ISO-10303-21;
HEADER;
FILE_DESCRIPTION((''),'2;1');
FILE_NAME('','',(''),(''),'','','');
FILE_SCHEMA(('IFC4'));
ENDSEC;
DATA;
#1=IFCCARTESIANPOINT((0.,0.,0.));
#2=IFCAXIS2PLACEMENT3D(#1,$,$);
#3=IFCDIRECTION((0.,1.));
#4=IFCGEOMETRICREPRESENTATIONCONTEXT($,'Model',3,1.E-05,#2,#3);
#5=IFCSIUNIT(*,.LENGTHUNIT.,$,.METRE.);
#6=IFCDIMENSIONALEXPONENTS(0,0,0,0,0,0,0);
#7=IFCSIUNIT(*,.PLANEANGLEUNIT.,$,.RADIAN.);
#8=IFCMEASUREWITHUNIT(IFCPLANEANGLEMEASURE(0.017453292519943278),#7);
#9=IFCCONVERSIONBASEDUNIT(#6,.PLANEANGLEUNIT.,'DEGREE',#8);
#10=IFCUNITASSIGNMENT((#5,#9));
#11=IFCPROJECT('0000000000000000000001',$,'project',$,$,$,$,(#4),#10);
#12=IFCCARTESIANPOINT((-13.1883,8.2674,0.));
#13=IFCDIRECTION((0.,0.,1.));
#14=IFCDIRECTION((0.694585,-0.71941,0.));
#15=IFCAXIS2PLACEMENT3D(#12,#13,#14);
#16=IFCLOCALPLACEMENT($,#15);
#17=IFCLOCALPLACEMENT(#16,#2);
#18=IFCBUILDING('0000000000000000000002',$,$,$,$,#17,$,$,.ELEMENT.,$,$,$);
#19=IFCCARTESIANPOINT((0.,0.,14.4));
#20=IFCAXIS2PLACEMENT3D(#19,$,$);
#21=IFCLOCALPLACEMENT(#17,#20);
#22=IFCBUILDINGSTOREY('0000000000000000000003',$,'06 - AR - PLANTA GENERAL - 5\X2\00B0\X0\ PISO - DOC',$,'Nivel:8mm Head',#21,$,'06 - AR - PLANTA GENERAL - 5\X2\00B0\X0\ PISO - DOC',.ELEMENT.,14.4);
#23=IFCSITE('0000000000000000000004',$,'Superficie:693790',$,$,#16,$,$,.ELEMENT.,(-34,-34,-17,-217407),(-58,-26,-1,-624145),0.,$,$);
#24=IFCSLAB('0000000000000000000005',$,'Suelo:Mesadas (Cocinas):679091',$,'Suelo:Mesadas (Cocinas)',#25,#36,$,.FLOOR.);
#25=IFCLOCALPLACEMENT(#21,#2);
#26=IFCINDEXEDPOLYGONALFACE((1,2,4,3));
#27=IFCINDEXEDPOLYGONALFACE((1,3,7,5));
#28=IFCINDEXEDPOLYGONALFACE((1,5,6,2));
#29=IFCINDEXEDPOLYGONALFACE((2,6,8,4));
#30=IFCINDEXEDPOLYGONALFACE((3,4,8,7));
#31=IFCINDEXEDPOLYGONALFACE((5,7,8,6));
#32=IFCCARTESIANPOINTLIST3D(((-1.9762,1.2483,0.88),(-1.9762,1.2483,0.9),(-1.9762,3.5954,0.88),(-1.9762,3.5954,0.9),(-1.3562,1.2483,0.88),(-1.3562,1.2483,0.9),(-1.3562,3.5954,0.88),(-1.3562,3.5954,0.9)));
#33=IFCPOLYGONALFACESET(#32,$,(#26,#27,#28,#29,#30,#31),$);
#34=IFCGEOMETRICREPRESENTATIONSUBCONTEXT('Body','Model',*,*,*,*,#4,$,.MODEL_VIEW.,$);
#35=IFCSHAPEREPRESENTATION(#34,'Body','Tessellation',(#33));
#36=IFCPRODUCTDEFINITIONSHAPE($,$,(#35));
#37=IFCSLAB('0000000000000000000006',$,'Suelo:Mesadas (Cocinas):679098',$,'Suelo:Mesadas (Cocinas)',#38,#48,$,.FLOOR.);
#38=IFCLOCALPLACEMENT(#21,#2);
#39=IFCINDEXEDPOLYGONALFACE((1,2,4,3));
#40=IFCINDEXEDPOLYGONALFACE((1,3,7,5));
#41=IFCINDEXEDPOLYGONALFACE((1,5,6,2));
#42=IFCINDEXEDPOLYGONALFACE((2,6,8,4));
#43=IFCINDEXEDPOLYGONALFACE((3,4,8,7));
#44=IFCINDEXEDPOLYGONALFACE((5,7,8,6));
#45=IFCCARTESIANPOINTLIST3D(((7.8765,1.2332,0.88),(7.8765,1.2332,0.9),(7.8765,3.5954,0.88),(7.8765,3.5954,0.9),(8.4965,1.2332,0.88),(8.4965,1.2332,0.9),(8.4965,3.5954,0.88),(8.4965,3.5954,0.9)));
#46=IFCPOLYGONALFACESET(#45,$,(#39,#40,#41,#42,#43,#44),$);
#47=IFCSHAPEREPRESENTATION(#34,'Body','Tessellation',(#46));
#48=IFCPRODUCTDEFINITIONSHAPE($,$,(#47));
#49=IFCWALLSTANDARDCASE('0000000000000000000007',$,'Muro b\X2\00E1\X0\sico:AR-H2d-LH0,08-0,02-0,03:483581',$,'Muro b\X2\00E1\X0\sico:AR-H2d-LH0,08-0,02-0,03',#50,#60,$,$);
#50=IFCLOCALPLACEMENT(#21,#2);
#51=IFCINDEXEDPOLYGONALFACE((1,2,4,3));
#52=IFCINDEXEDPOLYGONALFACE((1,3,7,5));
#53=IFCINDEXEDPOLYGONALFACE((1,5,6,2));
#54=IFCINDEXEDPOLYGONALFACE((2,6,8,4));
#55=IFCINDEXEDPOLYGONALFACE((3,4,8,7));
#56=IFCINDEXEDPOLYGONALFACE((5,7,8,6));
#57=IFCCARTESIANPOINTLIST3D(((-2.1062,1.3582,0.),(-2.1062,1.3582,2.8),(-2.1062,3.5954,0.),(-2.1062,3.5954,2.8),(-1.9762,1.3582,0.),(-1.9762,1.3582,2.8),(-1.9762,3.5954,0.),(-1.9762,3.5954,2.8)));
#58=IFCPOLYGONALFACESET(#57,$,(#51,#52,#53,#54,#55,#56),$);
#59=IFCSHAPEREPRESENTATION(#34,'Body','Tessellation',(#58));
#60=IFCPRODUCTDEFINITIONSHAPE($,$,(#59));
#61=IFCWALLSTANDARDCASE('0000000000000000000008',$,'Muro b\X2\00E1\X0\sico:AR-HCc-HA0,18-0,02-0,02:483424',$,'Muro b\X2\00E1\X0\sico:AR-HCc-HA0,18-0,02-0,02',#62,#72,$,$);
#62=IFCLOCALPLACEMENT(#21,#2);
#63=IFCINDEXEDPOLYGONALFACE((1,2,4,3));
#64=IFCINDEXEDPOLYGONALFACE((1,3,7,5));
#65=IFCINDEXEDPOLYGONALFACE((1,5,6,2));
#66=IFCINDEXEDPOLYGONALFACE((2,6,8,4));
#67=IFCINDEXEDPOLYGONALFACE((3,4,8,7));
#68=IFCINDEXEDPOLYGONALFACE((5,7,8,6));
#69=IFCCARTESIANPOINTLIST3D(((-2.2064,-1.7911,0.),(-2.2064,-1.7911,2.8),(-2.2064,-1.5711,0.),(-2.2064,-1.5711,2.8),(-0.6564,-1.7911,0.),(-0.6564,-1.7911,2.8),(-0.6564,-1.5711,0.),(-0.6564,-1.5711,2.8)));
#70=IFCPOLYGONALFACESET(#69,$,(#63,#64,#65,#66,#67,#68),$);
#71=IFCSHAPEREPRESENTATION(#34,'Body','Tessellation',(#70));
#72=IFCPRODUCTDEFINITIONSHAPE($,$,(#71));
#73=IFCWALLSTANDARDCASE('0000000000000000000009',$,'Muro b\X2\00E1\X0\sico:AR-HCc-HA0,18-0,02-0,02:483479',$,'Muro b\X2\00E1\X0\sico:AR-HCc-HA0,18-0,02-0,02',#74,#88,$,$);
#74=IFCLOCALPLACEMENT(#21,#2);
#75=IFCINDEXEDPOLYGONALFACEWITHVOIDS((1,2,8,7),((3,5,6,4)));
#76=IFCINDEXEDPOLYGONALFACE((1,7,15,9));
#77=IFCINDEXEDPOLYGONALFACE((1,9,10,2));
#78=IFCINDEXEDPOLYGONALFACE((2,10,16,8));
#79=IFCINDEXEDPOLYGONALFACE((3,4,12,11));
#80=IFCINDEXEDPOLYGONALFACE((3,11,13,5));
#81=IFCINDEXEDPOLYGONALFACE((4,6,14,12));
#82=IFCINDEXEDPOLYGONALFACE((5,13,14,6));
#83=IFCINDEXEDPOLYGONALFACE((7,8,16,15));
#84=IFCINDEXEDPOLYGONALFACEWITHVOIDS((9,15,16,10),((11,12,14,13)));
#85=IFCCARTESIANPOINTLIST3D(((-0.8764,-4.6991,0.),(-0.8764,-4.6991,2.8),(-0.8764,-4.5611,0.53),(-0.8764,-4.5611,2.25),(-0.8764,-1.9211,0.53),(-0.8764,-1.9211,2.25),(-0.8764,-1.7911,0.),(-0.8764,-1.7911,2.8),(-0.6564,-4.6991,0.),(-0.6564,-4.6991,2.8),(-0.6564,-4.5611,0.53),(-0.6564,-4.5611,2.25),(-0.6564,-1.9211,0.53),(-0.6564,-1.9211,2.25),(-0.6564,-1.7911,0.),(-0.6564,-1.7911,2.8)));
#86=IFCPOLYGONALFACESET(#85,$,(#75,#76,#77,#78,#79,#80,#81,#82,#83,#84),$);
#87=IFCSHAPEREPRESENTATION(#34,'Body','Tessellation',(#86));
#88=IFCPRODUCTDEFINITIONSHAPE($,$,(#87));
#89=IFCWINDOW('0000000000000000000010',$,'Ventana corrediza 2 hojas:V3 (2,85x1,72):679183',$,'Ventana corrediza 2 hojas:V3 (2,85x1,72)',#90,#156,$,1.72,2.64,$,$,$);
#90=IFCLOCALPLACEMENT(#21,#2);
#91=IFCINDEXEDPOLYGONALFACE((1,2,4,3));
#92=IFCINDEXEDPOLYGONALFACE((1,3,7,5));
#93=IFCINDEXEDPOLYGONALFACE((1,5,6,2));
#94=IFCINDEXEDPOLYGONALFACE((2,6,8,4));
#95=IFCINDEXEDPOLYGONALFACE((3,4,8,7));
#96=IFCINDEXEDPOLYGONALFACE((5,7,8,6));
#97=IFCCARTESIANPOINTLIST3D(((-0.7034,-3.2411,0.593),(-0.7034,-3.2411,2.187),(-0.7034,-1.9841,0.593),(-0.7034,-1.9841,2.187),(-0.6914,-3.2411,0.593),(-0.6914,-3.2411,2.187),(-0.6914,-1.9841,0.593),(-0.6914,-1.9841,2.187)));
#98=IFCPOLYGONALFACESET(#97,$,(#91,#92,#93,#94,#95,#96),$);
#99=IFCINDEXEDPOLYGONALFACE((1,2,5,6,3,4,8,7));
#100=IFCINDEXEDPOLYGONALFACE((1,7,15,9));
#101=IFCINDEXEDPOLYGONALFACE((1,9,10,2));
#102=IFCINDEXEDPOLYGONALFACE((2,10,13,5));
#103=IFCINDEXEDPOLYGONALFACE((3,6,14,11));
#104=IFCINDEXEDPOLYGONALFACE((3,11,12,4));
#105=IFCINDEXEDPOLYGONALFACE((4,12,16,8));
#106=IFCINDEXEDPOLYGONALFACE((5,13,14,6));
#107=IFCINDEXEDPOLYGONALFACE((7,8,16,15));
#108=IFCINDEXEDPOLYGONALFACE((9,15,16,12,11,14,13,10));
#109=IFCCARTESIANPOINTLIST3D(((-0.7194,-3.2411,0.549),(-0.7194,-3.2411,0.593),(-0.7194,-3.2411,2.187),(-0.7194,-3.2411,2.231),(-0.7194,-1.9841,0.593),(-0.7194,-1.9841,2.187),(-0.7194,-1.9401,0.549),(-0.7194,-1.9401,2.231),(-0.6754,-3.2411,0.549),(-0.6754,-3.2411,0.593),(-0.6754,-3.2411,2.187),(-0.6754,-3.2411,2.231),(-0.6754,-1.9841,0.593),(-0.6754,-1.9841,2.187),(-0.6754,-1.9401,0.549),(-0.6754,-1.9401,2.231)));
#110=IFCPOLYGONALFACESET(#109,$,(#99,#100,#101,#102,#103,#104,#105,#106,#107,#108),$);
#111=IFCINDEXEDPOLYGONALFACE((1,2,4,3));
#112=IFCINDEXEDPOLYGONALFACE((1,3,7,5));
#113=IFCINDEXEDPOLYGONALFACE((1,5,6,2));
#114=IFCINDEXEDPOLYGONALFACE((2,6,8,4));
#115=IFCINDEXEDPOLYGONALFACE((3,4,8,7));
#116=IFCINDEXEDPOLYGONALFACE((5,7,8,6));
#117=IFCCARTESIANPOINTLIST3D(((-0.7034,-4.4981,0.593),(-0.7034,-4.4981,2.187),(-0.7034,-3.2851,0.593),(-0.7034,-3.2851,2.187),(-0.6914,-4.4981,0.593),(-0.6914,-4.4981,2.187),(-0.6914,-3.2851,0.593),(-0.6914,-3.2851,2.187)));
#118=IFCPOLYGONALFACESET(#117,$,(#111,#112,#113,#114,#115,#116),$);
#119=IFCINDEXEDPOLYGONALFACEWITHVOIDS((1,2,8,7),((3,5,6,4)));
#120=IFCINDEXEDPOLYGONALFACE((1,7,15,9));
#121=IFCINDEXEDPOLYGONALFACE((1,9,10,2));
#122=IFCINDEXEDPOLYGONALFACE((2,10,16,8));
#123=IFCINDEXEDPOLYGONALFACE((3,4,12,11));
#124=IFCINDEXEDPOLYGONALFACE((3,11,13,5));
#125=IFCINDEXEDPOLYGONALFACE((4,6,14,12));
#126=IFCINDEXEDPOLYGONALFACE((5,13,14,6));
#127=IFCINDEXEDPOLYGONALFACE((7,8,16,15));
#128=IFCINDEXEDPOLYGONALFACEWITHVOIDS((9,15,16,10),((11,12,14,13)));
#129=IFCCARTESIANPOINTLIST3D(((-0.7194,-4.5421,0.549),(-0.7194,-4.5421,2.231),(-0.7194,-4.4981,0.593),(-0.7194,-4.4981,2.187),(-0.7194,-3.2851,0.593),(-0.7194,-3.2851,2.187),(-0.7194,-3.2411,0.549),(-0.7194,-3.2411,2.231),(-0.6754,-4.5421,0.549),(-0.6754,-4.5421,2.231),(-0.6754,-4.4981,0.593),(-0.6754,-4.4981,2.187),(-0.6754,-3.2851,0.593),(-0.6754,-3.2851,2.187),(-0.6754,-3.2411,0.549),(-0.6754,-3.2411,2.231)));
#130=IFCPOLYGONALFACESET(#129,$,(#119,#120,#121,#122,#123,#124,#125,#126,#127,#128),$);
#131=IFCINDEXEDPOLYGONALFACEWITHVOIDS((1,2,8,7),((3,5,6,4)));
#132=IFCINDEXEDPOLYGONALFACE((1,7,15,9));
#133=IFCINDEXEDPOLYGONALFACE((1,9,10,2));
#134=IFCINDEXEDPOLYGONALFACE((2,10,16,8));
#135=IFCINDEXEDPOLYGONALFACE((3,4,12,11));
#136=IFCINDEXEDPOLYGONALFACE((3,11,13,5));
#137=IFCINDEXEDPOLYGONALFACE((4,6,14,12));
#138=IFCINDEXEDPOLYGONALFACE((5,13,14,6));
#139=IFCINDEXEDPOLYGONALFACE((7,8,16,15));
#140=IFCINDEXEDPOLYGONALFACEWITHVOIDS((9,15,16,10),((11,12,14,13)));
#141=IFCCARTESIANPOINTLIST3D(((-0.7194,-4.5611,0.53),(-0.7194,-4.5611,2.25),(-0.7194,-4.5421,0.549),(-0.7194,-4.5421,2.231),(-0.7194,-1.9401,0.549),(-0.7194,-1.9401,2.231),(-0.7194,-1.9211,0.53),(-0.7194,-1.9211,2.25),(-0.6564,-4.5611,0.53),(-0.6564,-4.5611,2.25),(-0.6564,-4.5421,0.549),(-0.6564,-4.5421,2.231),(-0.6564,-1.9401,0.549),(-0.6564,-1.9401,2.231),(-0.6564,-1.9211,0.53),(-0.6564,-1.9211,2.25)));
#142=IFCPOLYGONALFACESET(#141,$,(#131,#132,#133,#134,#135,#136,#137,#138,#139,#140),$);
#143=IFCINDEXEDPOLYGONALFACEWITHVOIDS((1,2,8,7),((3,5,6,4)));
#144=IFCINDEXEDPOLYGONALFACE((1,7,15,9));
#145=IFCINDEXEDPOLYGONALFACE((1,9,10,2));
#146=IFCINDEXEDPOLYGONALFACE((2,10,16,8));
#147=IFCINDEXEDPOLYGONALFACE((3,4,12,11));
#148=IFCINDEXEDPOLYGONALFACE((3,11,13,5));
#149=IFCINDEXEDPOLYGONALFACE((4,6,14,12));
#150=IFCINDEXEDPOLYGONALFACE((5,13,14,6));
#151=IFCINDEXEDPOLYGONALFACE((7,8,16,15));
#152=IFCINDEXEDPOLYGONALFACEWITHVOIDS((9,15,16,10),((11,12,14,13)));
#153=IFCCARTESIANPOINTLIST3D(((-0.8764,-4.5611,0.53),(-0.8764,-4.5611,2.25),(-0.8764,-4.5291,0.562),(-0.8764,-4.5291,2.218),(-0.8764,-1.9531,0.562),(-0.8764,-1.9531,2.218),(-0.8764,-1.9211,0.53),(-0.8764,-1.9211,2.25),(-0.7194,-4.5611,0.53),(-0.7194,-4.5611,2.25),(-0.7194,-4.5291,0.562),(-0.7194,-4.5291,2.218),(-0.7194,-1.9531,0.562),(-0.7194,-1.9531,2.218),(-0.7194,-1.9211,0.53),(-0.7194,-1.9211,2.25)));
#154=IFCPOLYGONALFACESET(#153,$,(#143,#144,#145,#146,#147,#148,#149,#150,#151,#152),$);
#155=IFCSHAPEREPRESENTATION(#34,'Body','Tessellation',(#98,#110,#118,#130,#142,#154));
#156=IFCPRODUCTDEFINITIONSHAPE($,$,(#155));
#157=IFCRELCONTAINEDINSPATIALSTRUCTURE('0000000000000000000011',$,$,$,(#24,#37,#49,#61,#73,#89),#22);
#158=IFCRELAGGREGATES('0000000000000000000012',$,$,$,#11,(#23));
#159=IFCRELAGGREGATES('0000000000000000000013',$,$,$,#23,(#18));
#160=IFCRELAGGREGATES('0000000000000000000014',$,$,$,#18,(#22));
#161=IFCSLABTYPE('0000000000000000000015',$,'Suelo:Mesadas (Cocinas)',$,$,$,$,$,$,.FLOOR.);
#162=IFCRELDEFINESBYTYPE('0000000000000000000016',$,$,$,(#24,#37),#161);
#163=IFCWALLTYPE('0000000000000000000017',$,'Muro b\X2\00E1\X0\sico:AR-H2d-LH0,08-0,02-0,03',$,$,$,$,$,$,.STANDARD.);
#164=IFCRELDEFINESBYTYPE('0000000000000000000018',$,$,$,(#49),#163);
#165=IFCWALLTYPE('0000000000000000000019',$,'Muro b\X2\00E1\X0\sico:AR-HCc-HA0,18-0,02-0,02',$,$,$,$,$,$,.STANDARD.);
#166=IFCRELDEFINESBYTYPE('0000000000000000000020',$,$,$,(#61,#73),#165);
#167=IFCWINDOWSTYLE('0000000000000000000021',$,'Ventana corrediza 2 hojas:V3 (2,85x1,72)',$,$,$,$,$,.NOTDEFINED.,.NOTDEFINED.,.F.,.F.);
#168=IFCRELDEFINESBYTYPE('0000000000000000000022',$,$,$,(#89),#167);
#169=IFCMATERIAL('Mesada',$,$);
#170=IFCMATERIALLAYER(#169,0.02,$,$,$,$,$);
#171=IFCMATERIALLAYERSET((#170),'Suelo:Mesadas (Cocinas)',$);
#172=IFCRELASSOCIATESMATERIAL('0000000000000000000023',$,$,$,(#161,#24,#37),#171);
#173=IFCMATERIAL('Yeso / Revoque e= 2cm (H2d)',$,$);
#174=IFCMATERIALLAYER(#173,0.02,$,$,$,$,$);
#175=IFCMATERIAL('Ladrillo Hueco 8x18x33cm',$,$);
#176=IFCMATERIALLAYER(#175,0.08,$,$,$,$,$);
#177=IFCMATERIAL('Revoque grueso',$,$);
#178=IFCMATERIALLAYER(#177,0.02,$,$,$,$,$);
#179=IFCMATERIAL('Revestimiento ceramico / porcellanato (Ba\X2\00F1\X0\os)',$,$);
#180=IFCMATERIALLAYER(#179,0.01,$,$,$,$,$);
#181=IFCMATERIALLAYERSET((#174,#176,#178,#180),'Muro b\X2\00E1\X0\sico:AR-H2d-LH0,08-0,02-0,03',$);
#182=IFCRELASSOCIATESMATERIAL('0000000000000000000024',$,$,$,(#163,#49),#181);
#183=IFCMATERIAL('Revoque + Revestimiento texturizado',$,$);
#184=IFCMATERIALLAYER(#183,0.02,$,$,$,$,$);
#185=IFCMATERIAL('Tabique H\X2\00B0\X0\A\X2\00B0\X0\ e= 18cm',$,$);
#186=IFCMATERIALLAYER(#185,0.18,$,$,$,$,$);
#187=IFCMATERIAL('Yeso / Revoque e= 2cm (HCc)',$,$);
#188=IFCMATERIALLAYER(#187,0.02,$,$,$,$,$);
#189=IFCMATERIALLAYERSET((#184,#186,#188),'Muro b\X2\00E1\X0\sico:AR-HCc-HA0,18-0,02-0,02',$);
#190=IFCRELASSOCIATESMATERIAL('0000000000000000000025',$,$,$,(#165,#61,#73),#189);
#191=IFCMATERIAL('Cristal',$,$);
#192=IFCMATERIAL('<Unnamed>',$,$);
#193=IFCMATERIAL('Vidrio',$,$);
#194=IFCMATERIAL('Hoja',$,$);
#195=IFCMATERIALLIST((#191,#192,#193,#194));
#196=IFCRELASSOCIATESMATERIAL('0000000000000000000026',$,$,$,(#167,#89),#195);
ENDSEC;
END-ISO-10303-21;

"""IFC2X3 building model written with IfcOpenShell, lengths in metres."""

from ifc_helpers import new_model, entity, si_unit, converted_unit, direction, frame, frame_2d, origin, origin_2d_with_axis, place, context, subcontext, project, spatial, polyline, rectangle, outline, extrude, source, transform, mapped, material, material_list, layer, layer_set, layer_usage, type_object, type_shapes, element, fill, save


model = new_model("IFC2X3")

# Units and contexts
model_context = context("Model", 3, precision=1e-05, world=origin(), true_north=direction((0.0, 1.0)))
body_context = subcontext(model_context, "Body", "Model", "MODEL_VIEW")
ifc_project = project(units=[si_unit("LENGTHUNIT", "METRE"), converted_unit("PLANEANGLEUNIT", "DEGREE", entity("IfcPlaneAngleMeasure", 0.017453292519943278), si_unit("PLANEANGLEUNIT", "RADIAN"), dimensions=[0, 0, 0, 0, 0, 0, 0])], contexts=[model_context])

# Site, building, storey
site_placement = place(None, frame((-13.1883, 8.2674, 0.0), z_axis=(0.0, 0.0, 1.0), x_axis=(0.694585, -0.71941, 0.0)))
site = spatial("IfcSite", under=ifc_project, at=site_placement, Name="Superficie:693790", CompositionType="ELEMENT", RefLatitude=(-34, -34, -17, -217407), RefLongitude=(-58, -26, -1, -624145), RefElevation=0.0)
building_placement = place(site_placement, origin())
building = spatial("IfcBuilding", under=site, at=building_placement, CompositionType="ELEMENT")
storey_placement = place(building_placement, frame((0.0, 0.0, 14.4)))
storey = spatial("IfcBuildingStorey", under=building, at=storey_placement, Name="06 - AR - PLANTA GENERAL - 5° PISO - DOC", ObjectType="Nivel:8mm Head", LongName="06 - AR - PLANTA GENERAL - 5° PISO - DOC", CompositionType="ELEMENT", Elevation=14.4)

# Slabs
ifc_material_1 = material(Name="Mesada")
ifc_layer_1 = layer(ifc_material_1, 0.02)
ifc_layer_set_1 = layer_set([ifc_layer_1], Name="Suelo:Mesadas (Cocinas)")
ifc_layer_usage_1 = layer_usage(ifc_layer_set_1, "AXIS3", "POSITIVE", 0.0)
slab_type = type_object("IfcSlabType", Name="Suelo:Mesadas (Cocinas)", PredefinedType="FLOOR", material=ifc_layer_set_1)
slab_1_placement = place(storey_placement, origin())
element("IfcSlab", 1, at=slab_1_placement, inside=storey, type_object=slab_type, material=ifc_layer_usage_1, Name="Suelo:Mesadas (Cocinas):679091", ObjectType="Suelo:Mesadas (Cocinas)", PredefinedType="FLOOR", context=body_context, shape_type="SweptSolid", body=[
    extrude(rectangle(XDim=2.3472, YDim=0.62, at=origin_2d_with_axis()), frame((-1.6662, 2.4219, 0.9), z_axis=(0.0, 0.0, -1.0), x_axis=(0.0, 1.0, 0.0)), (0.0, 0.0, 1.0), 0.02),
])
ifc_layer_usage_2 = layer_usage(ifc_layer_set_1, "AXIS3", "POSITIVE", 0.0)
slab_2_placement = place(storey_placement, origin())
element("IfcSlab", 2, at=slab_2_placement, inside=storey, type_object=slab_type, material=ifc_layer_usage_2, Name="Suelo:Mesadas (Cocinas):679098", ObjectType="Suelo:Mesadas (Cocinas)", PredefinedType="FLOOR", context=body_context, shape_type="SweptSolid", body=[
    extrude(rectangle(XDim=2.3623, YDim=0.62, at=frame_2d((0.0, 0.0), x_axis=(1.0, 0.0))), frame((8.1865, 2.4143, 0.9), z_axis=(0.0, 0.0, -1.0), x_axis=(0.0, 1.0, 0.0)), (0.0, 0.0, 1.0), 0.02),
])

# Walls
ifc_material_2 = material(Name="Yeso / Revoque e= 2cm (H2d)")
ifc_layer_2 = layer(ifc_material_2, 0.02)
ifc_material_3 = material(Name="Ladrillo Hueco 8x18x33cm")
ifc_layer_3 = layer(ifc_material_3, 0.08)
ifc_material_4 = material(Name="Revoque grueso")
ifc_layer_4 = layer(ifc_material_4, 0.02)
ifc_material_5 = material(Name="Revestimiento ceramico / porcellanato (Baños)")
ifc_layer_5 = layer(ifc_material_5, 0.01)
ifc_layer_set_2 = layer_set([ifc_layer_2, ifc_layer_3, ifc_layer_4, ifc_layer_5], Name="Muro básico:AR-H2d-LH0,08-0,02-0,03")
ifc_layer_usage_3 = layer_usage(ifc_layer_set_2, "AXIS2", "POSITIVE", -0.065)
wall_type_1 = type_object("IfcWallType", Name="Muro básico:AR-H2d-LH0,08-0,02-0,03", PredefinedType="STANDARD", material=ifc_layer_set_2)
wall_1_placement = place(storey_placement, frame((-2.0412, 1.3582, 0.0), z_axis=(0.0, 0.0, 1.0), x_axis=(0.0, 1.0, 0.0)))
element("IfcWallStandardCase", 3, at=wall_1_placement, inside=storey, type_object=wall_type_1, material=ifc_layer_usage_3, Name="Muro básico:AR-H2d-LH0,08-0,02-0,03:483581", ObjectType="Muro básico:AR-H2d-LH0,08-0,02-0,03", context=body_context, shape_type="SweptSolid", body=[
    extrude(rectangle(XDim=2.2373, YDim=0.13, at=frame_2d((1.1186, 0.0), x_axis=(-1.0, 0.0))), origin(), (0.0, 0.0, 1.0), 2.8),
])
ifc_material_6 = material(Name="Revoque + Revestimiento texturizado")
ifc_layer_6 = layer(ifc_material_6, 0.02)
ifc_material_7 = material(Name="Tabique H°A° e= 18cm")
ifc_layer_7 = layer(ifc_material_7, 0.18)
ifc_material_8 = material(Name="Yeso / Revoque e= 2cm (HCc)")
ifc_layer_8 = layer(ifc_material_8, 0.02)
ifc_layer_set_3 = layer_set([ifc_layer_6, ifc_layer_7, ifc_layer_8], Name="Muro básico:AR-HCc-HA0,18-0,02-0,02")
ifc_layer_usage_4 = layer_usage(ifc_layer_set_3, "AXIS2", "NEGATIVE", 0.11)
wall_type_2 = type_object("IfcWallType", Name="Muro básico:AR-HCc-HA0,18-0,02-0,02", PredefinedType="STANDARD", material=ifc_layer_set_3)
wall_2_placement = place(storey_placement, frame((-2.2064, -1.6811, 0.0)))
element("IfcWallStandardCase", 4, at=wall_2_placement, inside=storey, type_object=wall_type_2, material=ifc_layer_usage_4, Name="Muro básico:AR-HCc-HA0,18-0,02-0,02:483424", ObjectType="Muro básico:AR-HCc-HA0,18-0,02-0,02", context=body_context, shape_type="SweptSolid", body=[
    extrude(rectangle(XDim=1.55, YDim=0.22, at=frame_2d((0.775, 0.0), x_axis=(-1.0, 0.0))), origin(), (0.0, 0.0, 1.0), 2.8),
])

# Wall, opening, window
ifc_layer_usage_5 = layer_usage(ifc_layer_set_3, "AXIS2", "NEGATIVE", 0.11)
wall_3_placement = place(storey_placement, frame((-0.7664, -1.7911, 0.0), z_axis=(0.0, 0.0, 1.0), x_axis=(0.0, -1.0, 0.0)))
wall_3 = element("IfcWallStandardCase", 5, at=wall_3_placement, inside=storey, type_object=wall_type_2, material=ifc_layer_usage_5, Name="Muro básico:AR-HCc-HA0,18-0,02-0,02:483479", ObjectType="Muro básico:AR-HCc-HA0,18-0,02-0,02", context=body_context, shape_type="SweptSolid", body=[
    extrude(rectangle(XDim=2.908, YDim=0.22, at=frame_2d((1.454, 0.0), x_axis=(-1.0, 0.0))), origin(), (0.0, 0.0, 1.0), 2.8),
])
opening_1_placement = place(wall_3_placement, frame((0.13, -0.11, 0.53)))
opening_1 = element("IfcOpeningElement", 6, at=opening_1_placement, cuts=wall_3, ObjectType="Opening", context=body_context, shape_type="SweptSolid", body=[
    extrude(rectangle(XDim=1.72, YDim=2.64, at=frame_2d((0.86, 1.32), x_axis=(1.0, 0.0))), frame((0.0, 0.0, 0.0), z_axis=(0.0, 1.0, 0.0), x_axis=(0.0, 0.0, 1.0)), (0.0, 0.0, 1.0), 0.22),
])
ifc_material_9 = material(Name="Cristal")
ifc_material_10 = material(Name="<Unnamed>")
ifc_material_11 = material(Name="Vidrio")
ifc_material_12 = material(Name="Hoja")
ifc_material_list_1 = material_list([ifc_material_9, ifc_material_10, ifc_material_11, ifc_material_12])
window_style = type_object("IfcWindowStyle", Name="Ventana corrediza 2 hojas:V3 (2,85x1,72)", ConstructionType="NOTDEFINED", OperationType="NOTDEFINED", ParameterTakesPrecedence=False, Sizeable=False, material=ifc_material_list_1)
shared_shape_1 = source(origin(), body_context, "Body", "SweptSolid", [
    extrude(rectangle(XDim=0.012, YDim=1.257, at=frame_2d((0.0, 0.0), x_axis=(1.0, 0.0))), frame((0.6915, 0.179, 0.063), z_axis=(0.0, 0.0, 1.0), x_axis=(0.0, -1.0, 0.0)), (0.0, 0.0, 1.0), 1.594),
    extrude(outline(polyline([(-0.6615, -0.841), (0.6395, -0.841), (0.6395, -0.797), (-0.6175, -0.797), (-0.6175, 0.797), (0.6395, 0.797), (0.6395, 0.841), (-0.6615, 0.841), (-0.6615, -0.841)])), frame((0.6805, 0.157, 0.86), z_axis=(0.0, 1.0, 0.0), x_axis=(1.0, 0.0, 0.0)), (0.0, 0.0, 1.0), 0.044),
    extrude(rectangle(XDim=0.012, YDim=1.213, at=frame_2d((0.0, 0.0), x_axis=(1.0, 0.0))), frame((1.9705, 0.179, 0.063), z_axis=(0.0, 0.0, 1.0), x_axis=(0.0, -1.0, 0.0)), (0.0, 0.0, 1.0), 1.594),
    extrude(outline(polyline([(-0.6505, -0.841), (0.6505, -0.841), (0.6505, 0.841), (-0.6505, 0.841), (-0.6505, -0.841)]), holes=[polyline([(-0.6065, -0.797), (-0.6065, 0.797), (0.6065, 0.797), (0.6065, -0.797), (-0.6065, -0.797)])]), frame((1.9705, 0.157, 0.86), z_axis=(0.0, 1.0, 0.0), x_axis=(1.0, 0.0, 0.0)), (0.0, 0.0, 1.0), 0.044),
    extrude(outline(polyline([(-1.32, -0.86), (1.32, -0.86), (1.32, 0.86), (-1.32, 0.86), (-1.32, -0.86)]), holes=[polyline([(-1.301, -0.841), (-1.301, 0.841), (1.301, 0.841), (1.301, -0.841), (-1.301, -0.841)])]), frame((1.32, 0.157, 0.86), z_axis=(0.0, 1.0, 0.0), x_axis=(1.0, 0.0, 0.0)), (0.0, 0.0, 1.0), 0.063),
    extrude(outline(polyline([(-1.32, -0.86), (1.32, -0.86), (1.32, 0.86), (-1.32, 0.86), (-1.32, -0.86)]), holes=[polyline([(-1.288, -0.828), (-1.288, 0.828), (1.288, 0.828), (1.288, -0.828), (-1.288, -0.828)])]), frame((1.32, 0.0, 0.86), z_axis=(0.0, 1.0, 0.0), x_axis=(1.0, 0.0, 0.0)), (0.0, 0.0, 1.0), 0.157),
])
type_shapes(window_style, [shared_shape_1])
window_placement = place(opening_1_placement, origin())
window = element("IfcWindow", 7, at=window_placement, inside=storey, type_object=window_style, material=ifc_material_list_1, Name="Ventana corrediza 2 hojas:V3 (2,85x1,72):679183", ObjectType="Ventana corrediza 2 hojas:V3 (2,85x1,72)", OverallHeight=1.72, OverallWidth=2.64, context=body_context, shape_type="MappedRepresentation", body=[
    mapped(shared_shape_1, transform((0.0, 0.0, 0.0), scale=1.0)),
])
fill(opening_1, window)

save(model, "model.ifc")
